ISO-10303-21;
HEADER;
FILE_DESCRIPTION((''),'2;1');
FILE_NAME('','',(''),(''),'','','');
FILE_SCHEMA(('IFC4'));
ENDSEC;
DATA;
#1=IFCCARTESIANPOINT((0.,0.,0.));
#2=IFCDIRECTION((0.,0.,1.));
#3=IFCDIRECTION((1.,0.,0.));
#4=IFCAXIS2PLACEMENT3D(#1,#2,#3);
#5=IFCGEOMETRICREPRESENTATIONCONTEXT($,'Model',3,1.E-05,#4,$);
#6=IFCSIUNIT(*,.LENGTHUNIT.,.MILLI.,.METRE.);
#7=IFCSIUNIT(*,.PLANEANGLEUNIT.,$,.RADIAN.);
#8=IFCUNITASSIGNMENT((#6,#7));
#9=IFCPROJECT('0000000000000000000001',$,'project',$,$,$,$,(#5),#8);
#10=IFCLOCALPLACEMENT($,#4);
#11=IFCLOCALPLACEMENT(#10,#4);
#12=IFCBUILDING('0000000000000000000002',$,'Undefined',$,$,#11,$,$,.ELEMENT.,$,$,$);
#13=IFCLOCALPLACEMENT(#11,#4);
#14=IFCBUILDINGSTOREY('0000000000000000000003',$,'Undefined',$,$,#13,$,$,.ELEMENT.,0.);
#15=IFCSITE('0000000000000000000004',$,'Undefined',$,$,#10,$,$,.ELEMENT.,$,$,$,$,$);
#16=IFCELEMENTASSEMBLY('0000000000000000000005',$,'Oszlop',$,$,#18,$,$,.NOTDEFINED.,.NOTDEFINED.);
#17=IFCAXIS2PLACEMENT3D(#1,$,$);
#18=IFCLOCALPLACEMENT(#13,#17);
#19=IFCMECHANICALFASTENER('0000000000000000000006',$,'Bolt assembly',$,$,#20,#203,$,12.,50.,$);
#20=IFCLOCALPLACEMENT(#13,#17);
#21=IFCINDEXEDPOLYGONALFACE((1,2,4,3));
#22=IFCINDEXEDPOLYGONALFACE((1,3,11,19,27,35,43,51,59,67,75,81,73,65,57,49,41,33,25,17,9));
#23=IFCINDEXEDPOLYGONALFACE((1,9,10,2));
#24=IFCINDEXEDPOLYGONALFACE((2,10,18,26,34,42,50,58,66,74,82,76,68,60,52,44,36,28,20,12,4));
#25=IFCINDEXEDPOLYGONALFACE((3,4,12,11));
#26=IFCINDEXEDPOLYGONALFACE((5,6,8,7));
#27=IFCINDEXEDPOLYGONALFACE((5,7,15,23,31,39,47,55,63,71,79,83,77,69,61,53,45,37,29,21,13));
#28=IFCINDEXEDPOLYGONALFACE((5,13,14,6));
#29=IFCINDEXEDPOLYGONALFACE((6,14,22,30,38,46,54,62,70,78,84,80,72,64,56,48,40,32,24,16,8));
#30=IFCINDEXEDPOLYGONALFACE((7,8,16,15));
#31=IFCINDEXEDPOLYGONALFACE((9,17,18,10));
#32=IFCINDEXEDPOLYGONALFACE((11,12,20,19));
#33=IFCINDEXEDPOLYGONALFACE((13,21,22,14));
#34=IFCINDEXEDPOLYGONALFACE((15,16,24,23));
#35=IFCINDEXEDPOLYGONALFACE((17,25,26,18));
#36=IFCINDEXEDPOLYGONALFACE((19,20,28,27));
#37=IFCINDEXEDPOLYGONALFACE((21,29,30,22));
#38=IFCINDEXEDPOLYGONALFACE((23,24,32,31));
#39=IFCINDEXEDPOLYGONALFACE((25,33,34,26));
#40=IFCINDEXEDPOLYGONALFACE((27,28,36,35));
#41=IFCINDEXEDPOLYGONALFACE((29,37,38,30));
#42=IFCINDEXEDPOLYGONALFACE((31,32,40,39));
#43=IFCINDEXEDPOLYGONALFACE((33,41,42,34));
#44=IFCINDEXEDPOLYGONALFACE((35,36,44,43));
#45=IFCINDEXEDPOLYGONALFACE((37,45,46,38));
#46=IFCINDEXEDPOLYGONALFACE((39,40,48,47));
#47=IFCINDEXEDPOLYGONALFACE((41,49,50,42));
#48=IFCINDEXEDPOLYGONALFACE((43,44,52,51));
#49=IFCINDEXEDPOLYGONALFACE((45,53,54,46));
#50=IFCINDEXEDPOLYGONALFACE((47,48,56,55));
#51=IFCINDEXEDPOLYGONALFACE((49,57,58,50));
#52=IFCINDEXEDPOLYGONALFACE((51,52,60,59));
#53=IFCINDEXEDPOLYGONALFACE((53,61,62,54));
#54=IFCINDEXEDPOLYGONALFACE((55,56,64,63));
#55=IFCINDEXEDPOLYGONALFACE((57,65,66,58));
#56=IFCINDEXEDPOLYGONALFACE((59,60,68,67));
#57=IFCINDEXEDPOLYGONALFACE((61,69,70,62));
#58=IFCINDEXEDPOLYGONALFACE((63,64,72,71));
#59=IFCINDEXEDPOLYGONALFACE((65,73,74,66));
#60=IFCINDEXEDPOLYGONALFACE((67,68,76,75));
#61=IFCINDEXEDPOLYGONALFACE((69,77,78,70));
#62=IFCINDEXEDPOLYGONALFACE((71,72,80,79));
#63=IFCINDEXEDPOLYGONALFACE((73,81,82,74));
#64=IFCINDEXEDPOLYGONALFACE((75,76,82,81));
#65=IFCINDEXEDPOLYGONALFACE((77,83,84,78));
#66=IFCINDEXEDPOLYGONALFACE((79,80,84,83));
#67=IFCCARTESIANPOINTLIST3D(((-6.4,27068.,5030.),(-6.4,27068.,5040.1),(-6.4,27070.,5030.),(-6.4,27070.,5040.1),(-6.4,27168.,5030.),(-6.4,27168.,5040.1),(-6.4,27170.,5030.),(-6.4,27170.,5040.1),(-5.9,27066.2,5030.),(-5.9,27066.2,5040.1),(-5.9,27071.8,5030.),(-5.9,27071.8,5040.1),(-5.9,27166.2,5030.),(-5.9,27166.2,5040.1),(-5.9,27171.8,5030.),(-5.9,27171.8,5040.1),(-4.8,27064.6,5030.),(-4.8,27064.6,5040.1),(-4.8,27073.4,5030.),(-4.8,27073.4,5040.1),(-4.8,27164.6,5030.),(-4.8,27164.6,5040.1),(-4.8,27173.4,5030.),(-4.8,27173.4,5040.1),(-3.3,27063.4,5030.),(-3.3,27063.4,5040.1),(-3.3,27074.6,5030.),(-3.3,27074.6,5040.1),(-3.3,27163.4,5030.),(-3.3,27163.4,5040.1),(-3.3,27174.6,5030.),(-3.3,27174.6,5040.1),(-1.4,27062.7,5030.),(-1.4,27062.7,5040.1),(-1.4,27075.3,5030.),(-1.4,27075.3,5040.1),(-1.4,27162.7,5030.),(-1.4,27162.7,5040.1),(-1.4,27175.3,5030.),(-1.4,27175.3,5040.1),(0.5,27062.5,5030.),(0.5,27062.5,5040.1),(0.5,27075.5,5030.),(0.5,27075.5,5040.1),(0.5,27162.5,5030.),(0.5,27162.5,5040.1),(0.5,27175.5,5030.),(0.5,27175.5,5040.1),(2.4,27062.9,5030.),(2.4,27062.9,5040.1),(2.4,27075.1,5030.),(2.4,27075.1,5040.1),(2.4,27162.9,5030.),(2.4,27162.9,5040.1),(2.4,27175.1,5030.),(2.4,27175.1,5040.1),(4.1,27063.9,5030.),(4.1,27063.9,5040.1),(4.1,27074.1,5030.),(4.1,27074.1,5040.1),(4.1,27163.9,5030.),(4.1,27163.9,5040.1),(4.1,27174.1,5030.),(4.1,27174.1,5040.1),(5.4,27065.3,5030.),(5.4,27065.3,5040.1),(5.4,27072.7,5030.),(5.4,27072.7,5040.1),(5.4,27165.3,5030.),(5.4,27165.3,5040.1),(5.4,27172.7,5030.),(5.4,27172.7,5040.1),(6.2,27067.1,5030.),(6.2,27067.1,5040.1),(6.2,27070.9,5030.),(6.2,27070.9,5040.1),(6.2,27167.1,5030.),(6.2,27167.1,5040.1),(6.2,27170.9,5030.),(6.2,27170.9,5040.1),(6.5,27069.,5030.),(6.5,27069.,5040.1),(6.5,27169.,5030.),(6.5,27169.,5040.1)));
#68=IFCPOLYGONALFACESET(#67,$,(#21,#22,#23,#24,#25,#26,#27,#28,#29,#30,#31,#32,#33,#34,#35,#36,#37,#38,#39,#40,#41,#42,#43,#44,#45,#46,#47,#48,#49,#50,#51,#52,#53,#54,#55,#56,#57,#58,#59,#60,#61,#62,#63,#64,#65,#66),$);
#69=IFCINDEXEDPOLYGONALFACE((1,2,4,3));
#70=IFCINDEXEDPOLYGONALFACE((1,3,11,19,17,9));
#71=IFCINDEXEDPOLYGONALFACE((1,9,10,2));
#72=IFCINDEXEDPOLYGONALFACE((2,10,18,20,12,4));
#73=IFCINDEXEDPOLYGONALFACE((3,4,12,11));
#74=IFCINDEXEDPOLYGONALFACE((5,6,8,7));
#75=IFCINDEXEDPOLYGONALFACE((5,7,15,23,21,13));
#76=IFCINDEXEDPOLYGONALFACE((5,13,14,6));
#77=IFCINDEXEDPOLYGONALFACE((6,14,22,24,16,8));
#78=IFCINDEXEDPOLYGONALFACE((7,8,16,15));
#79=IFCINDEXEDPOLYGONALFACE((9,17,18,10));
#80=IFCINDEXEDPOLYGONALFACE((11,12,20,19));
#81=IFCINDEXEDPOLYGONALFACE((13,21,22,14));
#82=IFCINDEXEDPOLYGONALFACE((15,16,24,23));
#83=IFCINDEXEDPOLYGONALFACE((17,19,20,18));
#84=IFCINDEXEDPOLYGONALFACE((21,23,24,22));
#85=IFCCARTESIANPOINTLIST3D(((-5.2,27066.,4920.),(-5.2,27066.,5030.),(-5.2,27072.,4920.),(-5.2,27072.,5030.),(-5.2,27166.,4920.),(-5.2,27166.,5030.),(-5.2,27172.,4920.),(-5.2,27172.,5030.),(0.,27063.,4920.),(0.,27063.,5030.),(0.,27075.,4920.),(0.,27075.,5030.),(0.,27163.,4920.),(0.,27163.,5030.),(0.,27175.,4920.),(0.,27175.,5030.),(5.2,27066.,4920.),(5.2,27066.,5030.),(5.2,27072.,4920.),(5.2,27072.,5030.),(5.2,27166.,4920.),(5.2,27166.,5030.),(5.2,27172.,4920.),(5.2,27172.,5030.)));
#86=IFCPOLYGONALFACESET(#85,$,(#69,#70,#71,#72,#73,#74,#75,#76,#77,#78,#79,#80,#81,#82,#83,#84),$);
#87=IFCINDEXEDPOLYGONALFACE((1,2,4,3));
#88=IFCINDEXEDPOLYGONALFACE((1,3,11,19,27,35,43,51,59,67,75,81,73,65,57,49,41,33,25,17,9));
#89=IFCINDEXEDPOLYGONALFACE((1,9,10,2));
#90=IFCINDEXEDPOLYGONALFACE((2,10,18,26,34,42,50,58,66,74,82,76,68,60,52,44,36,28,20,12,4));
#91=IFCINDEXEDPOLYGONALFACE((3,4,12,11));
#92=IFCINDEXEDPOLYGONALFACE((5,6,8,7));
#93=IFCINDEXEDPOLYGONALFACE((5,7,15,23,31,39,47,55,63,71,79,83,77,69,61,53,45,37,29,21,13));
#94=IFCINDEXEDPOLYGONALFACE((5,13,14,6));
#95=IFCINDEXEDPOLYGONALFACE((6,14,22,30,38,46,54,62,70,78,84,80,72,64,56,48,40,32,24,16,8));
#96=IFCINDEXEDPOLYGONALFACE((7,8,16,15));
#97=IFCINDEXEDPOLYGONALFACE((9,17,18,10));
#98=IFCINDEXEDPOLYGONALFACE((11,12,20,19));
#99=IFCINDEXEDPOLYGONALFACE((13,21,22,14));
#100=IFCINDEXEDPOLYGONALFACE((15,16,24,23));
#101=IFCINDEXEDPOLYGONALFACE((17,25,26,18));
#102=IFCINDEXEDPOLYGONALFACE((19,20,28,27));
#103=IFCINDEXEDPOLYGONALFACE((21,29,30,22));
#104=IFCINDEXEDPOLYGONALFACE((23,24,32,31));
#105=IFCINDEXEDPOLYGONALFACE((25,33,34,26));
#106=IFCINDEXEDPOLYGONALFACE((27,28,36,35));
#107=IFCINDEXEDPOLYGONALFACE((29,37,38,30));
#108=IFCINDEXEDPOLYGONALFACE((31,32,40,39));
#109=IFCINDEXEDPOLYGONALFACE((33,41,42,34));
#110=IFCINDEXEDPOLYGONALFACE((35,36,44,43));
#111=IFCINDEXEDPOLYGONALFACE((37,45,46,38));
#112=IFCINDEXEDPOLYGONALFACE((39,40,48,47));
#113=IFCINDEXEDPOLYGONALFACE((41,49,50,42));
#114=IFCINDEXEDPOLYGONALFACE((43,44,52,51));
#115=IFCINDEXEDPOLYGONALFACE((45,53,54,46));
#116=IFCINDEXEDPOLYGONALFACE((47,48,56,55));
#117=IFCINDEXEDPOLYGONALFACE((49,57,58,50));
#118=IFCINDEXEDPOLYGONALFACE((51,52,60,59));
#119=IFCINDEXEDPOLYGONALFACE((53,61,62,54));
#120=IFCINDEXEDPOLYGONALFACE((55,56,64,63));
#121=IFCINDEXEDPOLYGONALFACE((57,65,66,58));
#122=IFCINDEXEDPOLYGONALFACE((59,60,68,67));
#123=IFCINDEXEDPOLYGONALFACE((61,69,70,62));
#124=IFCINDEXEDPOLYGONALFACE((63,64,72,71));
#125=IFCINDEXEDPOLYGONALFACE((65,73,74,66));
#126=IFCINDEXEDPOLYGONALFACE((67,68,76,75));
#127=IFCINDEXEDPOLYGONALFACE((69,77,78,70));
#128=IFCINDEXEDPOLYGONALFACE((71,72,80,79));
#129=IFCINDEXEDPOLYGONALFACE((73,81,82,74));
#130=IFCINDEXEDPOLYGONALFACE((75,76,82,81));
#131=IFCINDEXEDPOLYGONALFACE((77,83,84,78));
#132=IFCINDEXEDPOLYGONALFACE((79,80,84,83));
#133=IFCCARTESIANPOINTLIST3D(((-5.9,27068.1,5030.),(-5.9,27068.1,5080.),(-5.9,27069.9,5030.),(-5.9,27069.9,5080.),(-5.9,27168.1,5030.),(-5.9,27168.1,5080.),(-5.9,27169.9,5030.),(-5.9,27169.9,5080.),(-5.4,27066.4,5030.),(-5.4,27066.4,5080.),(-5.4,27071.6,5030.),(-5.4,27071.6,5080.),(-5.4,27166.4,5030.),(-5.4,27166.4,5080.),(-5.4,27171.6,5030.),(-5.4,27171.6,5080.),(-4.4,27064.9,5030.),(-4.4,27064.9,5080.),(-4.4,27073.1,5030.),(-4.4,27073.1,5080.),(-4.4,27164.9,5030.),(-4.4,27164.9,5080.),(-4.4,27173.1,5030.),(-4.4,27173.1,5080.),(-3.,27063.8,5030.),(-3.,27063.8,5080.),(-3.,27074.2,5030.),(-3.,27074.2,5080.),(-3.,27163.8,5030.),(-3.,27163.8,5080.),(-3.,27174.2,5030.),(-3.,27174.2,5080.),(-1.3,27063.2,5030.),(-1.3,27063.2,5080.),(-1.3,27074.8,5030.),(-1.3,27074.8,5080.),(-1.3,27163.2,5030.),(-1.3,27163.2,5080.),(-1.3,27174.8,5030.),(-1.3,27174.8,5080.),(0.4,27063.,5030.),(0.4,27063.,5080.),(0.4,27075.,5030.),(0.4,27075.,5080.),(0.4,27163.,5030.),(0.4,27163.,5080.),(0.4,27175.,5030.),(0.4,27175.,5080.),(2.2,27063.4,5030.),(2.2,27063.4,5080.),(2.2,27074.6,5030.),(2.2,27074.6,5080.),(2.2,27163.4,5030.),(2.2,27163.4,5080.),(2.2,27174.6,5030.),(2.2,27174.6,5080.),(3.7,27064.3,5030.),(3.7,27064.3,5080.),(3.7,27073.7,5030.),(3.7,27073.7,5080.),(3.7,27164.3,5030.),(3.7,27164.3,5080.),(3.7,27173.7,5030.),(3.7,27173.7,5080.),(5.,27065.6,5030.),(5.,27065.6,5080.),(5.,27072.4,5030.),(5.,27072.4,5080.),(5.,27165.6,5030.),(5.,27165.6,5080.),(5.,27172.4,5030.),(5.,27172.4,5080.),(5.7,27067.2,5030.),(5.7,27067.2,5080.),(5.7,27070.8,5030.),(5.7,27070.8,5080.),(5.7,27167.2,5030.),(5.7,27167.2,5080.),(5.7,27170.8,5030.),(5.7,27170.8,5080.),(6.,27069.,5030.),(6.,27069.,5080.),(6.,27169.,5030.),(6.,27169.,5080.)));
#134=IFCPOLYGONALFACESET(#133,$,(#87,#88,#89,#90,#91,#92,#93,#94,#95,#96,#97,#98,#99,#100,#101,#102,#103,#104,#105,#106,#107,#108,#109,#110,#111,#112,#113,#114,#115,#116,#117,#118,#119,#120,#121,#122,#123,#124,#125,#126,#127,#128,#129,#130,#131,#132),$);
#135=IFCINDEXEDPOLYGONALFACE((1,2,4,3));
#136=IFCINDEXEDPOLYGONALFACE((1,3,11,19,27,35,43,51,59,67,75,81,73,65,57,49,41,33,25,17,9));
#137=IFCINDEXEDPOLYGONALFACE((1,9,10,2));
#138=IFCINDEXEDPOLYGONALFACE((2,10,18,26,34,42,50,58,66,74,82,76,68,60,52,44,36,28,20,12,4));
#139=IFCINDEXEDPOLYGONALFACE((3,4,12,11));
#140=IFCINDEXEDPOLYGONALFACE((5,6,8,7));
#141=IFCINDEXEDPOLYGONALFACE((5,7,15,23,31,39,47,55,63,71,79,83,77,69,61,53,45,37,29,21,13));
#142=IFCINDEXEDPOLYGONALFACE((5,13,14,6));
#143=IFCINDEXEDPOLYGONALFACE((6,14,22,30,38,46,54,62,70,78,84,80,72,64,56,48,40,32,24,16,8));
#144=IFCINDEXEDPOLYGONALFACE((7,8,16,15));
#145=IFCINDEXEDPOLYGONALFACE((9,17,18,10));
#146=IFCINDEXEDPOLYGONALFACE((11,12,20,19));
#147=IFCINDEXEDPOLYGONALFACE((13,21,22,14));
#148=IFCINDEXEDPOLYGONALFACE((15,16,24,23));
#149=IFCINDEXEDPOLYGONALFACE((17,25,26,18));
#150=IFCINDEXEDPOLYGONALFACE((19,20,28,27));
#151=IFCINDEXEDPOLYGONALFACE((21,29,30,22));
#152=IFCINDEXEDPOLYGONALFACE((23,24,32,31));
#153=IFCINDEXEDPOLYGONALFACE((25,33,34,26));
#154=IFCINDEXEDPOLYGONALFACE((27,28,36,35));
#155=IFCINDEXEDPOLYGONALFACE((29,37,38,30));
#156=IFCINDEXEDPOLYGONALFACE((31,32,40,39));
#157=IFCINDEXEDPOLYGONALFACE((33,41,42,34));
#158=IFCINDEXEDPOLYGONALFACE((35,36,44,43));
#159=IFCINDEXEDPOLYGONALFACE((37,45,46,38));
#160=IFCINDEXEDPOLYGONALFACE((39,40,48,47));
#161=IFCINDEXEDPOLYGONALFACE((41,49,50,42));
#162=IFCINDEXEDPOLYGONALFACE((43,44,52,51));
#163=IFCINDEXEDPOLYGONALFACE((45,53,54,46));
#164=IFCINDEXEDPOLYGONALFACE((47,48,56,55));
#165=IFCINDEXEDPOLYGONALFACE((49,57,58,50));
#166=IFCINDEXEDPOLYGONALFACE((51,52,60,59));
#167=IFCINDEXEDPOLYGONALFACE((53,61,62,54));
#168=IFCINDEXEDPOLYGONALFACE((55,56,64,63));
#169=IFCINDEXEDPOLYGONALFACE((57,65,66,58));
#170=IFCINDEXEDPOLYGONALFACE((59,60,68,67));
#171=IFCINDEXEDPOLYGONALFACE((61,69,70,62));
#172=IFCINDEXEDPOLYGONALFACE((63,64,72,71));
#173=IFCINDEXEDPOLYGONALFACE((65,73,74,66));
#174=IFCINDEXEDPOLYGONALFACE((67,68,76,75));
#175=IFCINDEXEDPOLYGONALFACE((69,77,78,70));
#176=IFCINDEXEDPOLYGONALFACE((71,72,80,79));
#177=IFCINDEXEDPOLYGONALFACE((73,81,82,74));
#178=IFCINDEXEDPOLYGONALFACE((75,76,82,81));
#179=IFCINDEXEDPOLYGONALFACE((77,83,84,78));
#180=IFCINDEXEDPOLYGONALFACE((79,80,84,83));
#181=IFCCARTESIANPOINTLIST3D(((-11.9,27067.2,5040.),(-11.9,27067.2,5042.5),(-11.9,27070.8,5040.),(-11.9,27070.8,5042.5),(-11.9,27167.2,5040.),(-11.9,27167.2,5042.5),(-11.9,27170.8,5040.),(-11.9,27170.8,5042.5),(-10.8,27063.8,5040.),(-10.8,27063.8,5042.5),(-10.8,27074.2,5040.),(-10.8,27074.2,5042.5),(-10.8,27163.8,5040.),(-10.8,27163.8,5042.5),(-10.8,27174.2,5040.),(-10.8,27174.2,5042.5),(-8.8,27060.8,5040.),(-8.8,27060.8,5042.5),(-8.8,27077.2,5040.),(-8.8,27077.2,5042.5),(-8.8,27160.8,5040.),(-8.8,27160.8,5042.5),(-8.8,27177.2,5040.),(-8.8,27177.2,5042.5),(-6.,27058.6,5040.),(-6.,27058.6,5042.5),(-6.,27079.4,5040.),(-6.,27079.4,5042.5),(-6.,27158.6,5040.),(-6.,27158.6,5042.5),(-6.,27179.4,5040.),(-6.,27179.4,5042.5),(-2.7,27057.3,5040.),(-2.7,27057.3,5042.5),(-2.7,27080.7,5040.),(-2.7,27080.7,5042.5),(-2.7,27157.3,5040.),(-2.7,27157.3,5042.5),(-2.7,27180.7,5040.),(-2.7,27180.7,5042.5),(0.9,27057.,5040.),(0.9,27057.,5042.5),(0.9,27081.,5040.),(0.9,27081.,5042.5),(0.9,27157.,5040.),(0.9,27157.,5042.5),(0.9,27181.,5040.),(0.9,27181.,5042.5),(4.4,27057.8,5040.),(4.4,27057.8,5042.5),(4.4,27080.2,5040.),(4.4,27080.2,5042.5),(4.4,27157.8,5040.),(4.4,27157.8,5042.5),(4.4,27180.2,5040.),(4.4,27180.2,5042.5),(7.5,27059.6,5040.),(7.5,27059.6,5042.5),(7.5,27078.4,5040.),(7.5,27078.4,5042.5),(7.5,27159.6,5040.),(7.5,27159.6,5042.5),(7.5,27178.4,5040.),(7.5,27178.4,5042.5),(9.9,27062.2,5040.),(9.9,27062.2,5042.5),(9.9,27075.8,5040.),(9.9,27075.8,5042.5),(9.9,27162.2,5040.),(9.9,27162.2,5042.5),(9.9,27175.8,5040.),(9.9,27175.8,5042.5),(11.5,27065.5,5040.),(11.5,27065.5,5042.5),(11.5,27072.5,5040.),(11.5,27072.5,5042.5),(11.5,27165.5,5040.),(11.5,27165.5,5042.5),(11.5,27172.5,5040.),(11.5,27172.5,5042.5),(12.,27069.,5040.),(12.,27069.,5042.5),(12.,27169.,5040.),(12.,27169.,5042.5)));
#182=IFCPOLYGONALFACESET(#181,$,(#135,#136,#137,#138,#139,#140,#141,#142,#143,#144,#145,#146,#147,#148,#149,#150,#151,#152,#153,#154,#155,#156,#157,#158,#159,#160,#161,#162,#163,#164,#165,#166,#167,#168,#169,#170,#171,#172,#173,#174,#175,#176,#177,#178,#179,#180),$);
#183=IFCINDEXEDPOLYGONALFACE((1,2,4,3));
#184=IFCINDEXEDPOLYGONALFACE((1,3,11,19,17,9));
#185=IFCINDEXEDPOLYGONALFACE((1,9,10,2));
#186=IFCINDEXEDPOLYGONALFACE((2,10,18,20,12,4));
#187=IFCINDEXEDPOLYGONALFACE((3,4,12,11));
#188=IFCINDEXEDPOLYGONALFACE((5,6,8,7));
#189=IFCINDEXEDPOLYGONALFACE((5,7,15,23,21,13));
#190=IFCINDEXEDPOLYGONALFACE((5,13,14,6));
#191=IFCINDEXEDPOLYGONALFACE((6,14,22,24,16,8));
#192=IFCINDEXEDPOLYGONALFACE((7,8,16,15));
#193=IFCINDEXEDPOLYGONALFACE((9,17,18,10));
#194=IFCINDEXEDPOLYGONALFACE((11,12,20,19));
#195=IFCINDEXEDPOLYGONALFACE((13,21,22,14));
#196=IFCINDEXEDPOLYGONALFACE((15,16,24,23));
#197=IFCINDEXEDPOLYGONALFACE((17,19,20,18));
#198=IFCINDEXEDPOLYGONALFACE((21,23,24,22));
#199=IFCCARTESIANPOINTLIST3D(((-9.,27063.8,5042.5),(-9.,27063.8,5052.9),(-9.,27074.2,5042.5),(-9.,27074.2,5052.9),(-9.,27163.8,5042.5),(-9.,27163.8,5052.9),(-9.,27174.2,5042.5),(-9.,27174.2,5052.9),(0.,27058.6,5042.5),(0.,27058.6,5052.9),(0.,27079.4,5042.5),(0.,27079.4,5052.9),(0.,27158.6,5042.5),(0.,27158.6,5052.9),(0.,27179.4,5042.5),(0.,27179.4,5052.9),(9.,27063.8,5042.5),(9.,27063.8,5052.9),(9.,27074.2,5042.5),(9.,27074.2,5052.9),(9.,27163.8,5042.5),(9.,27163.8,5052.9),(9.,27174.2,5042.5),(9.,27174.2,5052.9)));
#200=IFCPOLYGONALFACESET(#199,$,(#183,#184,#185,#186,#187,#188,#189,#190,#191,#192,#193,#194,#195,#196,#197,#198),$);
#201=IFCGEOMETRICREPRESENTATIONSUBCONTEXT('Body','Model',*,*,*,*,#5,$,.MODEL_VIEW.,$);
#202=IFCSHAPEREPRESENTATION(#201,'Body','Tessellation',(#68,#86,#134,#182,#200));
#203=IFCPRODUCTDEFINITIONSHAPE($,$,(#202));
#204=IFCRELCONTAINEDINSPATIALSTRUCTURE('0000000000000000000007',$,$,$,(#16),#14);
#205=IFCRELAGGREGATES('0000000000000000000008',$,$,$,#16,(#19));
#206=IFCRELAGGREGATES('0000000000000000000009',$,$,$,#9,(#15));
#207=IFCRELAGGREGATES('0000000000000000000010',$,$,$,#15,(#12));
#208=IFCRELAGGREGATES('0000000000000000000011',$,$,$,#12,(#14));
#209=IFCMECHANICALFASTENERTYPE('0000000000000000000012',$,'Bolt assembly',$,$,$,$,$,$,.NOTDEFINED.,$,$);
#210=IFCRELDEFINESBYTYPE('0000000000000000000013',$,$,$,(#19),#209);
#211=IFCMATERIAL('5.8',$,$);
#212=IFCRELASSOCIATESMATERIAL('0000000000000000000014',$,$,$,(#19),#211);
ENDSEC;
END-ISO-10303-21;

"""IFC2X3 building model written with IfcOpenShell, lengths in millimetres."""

from ifc_helpers import new_model, si_unit, frame, origin_with_axes, origin_2d_with_axis, place, context, subcontext, project, spatial, polyline, circle, outline, extrude, source, transform, mapped, material, type_object, element, aggregate, save


model = new_model("IFC2X3")

# Units and contexts
model_context = context("Model", 3, precision=1e-05, world=origin_with_axes())
body_context = subcontext(model_context, "Body", "Model", "MODEL_VIEW")
ifc_project = project(units=[si_unit("LENGTHUNIT", "METRE", prefix="MILLI"), si_unit("PLANEANGLEUNIT", "RADIAN")], contexts=[model_context])

# Site, building, storey
site_placement = place(None, origin_with_axes())
site = spatial("IfcSite", under=ifc_project, at=site_placement, Name="Undefined", CompositionType="ELEMENT")
building_placement = place(site_placement, origin_with_axes())
building = spatial("IfcBuilding", under=site, at=building_placement, Name="Undefined", CompositionType="ELEMENT")
storey_placement = place(building_placement, origin_with_axes())
storey = spatial("IfcBuildingStorey", under=building, at=storey_placement, Name="Undefined", CompositionType="ELEMENT", Elevation=0.0)

# Element assembly
assembly_1_placement = place(storey_placement, origin_with_axes())
assembly_1 = element("IfcElementAssembly", 1, at=assembly_1_placement, inside=storey, Name="Oszlop", AssemblyPlace="NOTDEFINED", PredefinedType="NOTDEFINED")

# Mechanical fastener
ifc_material_1 = material(Name="5.8")
mechanical_fastener_type = type_object("IfcMechanicalFastenerType", Name="Bolt assembly")
shared_shape_1 = source(origin_with_axes(), body_context, "Body", "SweptSolid", [
    extrude(circle(Radius=6.5, at=origin_2d_with_axis()), frame((0.0, -10.0, 0.0), z_axis=(0.0, 1.0, 0.0), x_axis=(1.0, 0.0, 0.0)), (0.0, 0.0, 1.0), 10.1),
    extrude(outline(polyline([(5.2, -3.0), (5.2, 3.0), (0.0, 6.0), (-5.2, 3.0), (-5.2, -3.0), (0.0, -6.0), (5.2, -3.0)])), frame((0.0, -120.0, 0.0), z_axis=(0.0, 1.0, 0.0), x_axis=(1.0, 0.0, 0.0)), (0.0, 0.0, 1.0), 110.0),
    extrude(circle(Radius=6.0, at=origin_2d_with_axis()), frame((0.0, -10.0, 0.0), z_axis=(0.0, 1.0, 0.0), x_axis=(1.0, 0.0, 0.0)), (0.0, 0.0, 1.0), 50.0),
    extrude(circle(Radius=12.0, at=origin_2d_with_axis()), frame((0.0, 0.0, 0.0), z_axis=(0.0, 1.0, 0.0), x_axis=(1.0, 0.0, 0.0)), (0.0, 0.0, 1.0), 2.5),
    extrude(outline(polyline([(9.0, -5.2), (9.0, 5.2), (0.0, 10.4), (-9.0, 5.2), (-9.0, -5.2), (0.0, -10.4), (9.0, -5.2)])), frame((0.0, 2.5, 0.0), z_axis=(0.0, 1.0, 0.0), x_axis=(1.0, 0.0, 0.0)), (0.0, 0.0, 1.0), 10.4),
])
mechanical_fastener_1_placement = place(assembly_1_placement, frame((-48.0, 27119.0, 5040.0), z_axis=(0.0, -1.0, 0.0), x_axis=(1.0, 0.0, 0.0)))
mechanical_fastener_1 = element("IfcMechanicalFastener", 2, at=mechanical_fastener_1_placement, type_object=mechanical_fastener_type, material=ifc_material_1, Name="Bolt assembly", NominalDiameter=12.0, NominalLength=50.0, context=body_context, shape_type="MappedRepresentation", body=[
    mapped(shared_shape_1, transform((48.0, 0.0, -50.0))),
    mapped(shared_shape_1, transform((48.0, 0.0, 50.0))),
])
aggregate(assembly_1, [mechanical_fastener_1])

save(model, "model.ifc")
